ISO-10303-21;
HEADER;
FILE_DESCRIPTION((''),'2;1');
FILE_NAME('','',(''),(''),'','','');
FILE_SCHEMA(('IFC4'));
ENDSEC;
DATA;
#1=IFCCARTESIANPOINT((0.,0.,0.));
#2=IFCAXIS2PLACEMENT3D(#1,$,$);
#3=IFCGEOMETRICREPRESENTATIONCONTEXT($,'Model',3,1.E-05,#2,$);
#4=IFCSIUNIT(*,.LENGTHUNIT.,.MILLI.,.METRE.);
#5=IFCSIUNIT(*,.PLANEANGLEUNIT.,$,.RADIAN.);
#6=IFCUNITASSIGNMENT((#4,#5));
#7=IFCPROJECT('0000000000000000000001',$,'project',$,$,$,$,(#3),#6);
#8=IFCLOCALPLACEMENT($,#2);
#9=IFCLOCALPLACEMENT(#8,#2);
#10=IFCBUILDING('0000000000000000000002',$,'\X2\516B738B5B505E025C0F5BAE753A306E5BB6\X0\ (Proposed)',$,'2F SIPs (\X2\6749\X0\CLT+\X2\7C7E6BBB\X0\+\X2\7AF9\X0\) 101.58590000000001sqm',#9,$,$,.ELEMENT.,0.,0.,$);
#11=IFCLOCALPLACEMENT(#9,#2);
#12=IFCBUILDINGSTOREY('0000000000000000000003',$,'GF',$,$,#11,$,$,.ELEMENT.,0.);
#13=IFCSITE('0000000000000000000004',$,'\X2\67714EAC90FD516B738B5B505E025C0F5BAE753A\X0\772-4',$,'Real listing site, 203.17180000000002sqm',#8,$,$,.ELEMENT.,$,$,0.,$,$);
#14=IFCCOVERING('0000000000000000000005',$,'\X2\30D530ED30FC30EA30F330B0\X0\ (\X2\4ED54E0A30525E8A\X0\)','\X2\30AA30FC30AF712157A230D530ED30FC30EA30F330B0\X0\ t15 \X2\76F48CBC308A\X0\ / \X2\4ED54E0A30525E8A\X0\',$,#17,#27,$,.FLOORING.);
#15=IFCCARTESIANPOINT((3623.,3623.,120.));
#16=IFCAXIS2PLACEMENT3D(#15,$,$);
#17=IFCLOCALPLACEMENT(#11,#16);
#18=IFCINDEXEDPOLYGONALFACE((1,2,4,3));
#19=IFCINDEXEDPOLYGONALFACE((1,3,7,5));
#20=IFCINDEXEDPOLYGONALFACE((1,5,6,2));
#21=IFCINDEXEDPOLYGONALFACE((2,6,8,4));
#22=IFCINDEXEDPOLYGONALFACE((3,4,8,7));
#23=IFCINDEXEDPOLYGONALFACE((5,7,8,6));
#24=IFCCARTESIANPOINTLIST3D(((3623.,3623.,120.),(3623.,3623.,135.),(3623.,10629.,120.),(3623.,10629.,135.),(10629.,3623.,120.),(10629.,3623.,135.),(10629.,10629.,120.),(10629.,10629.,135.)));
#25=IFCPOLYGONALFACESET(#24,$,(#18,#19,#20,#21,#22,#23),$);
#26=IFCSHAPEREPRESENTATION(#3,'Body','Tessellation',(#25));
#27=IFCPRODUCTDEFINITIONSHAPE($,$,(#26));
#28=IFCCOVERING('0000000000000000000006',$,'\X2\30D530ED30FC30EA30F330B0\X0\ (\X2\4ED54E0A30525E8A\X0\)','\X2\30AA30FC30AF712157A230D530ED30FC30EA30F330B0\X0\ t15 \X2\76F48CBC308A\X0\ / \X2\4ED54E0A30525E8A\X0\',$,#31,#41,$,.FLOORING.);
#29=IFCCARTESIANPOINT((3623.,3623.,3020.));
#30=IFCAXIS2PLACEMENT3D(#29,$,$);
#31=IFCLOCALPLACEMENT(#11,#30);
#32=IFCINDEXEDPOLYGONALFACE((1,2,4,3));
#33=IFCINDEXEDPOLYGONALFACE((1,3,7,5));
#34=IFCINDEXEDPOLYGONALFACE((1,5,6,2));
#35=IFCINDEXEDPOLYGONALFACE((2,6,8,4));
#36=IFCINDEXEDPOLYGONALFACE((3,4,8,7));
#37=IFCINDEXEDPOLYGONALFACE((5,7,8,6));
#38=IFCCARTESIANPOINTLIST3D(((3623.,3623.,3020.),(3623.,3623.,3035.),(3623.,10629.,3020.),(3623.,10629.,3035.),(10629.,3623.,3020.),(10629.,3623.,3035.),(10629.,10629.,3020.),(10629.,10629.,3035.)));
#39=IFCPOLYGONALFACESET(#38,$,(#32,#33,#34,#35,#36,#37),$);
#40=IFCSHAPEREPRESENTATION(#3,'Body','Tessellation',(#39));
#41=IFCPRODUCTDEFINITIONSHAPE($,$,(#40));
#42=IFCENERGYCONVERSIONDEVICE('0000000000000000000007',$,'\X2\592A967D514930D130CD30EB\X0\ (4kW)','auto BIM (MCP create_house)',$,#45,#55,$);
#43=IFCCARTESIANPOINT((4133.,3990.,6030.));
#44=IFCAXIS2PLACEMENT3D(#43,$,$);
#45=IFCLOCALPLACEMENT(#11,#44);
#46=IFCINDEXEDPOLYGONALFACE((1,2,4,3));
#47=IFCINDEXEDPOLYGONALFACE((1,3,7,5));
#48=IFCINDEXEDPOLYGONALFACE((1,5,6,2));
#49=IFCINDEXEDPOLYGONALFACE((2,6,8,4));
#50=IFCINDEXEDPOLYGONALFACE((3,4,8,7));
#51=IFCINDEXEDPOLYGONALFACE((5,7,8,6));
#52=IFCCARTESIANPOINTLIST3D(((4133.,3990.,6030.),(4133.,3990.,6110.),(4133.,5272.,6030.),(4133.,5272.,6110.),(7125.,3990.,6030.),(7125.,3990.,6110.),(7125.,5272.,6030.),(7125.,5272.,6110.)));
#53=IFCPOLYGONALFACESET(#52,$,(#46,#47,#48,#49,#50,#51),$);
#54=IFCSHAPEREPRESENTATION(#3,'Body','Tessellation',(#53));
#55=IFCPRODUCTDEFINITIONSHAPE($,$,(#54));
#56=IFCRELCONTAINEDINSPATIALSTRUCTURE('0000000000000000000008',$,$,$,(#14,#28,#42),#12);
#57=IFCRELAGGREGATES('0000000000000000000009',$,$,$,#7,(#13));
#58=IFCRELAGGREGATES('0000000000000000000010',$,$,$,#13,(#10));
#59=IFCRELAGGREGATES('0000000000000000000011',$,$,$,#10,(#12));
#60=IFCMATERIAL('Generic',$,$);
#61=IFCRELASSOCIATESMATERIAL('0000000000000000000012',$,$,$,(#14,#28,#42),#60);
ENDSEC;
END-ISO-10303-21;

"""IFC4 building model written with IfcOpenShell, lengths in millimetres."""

from ifc_helpers import new_model, si_unit, frame, frame_2d, origin, place, context, project, spatial, rectangle, extrude, material, element, save


model = new_model("IFC4")

# Units and contexts
model_context = context("Model", 3, precision=1e-05, world=origin())
ifc_project = project(units=[si_unit("LENGTHUNIT", "METRE", prefix="MILLI"), si_unit("PLANEANGLEUNIT", "RADIAN")], contexts=[model_context])

# Site, building, storey
site_placement = place(None, origin())
site = spatial("IfcSite", under=ifc_project, at=site_placement, Name="東京都八王子市小宮町772-4", ObjectType="Real listing site, 203.17180000000002sqm", CompositionType="ELEMENT", RefElevation=0.0)
building_placement = place(site_placement, origin())
building = spatial("IfcBuilding", under=site, at=building_placement, Name="八王子市小宮町の家 (Proposed)", ObjectType="2F SIPs (杉CLT+籾殻+竹) 101.58590000000001sqm", CompositionType="ELEMENT", ElevationOfRefHeight=0.0, ElevationOfTerrain=0.0)
storey_placement = place(building_placement, origin())
storey = spatial("IfcBuildingStorey", under=building, at=storey_placement, Name="GF", CompositionType="ELEMENT", Elevation=0.0)

# Coverings
ifc_material_1 = material(Name="Generic")
covering_1_placement = place(storey_placement, frame((3623.0, 3623.0, 120.0)))
element("IfcCovering", 1, at=covering_1_placement, inside=storey, material=ifc_material_1, Name="フローリング (仕上げ床)", Description="オーク無垢フローリング t15 直貼り / 仕上げ床", PredefinedType="FLOORING", context=model_context, shape_type="SweptSolid", body=[
    extrude(rectangle(XDim=7006.0, YDim=7006.0, at=frame_2d((3503.0, 3503.0))), frame((3623.0, 3623.0, 120.0)), (0.0, 0.0, 1.0), 15.0),
])
covering_2_placement = place(storey_placement, frame((3623.0, 3623.0, 3020.0)))
element("IfcCovering", 2, at=covering_2_placement, inside=storey, material=ifc_material_1, Name="フローリング (仕上げ床)", Description="オーク無垢フローリング t15 直貼り / 仕上げ床", PredefinedType="FLOORING", context=model_context, shape_type="SweptSolid", body=[
    extrude(rectangle(XDim=7006.0, YDim=7006.0, at=frame_2d((3503.0, 3503.0))), frame((3623.0, 3623.0, 3020.0)), (0.0, 0.0, 1.0), 15.0),
])

# Energy conversion device
energy_conversion_device_placement = place(storey_placement, frame((4133.0, 3990.0, 6030.0)))
element("IfcEnergyConversionDevice", 3, at=energy_conversion_device_placement, inside=storey, material=ifc_material_1, Name="太陽光パネル (4kW)", Description="auto BIM (MCP create_house)", context=model_context, shape_type="SweptSolid", body=[
    extrude(rectangle(XDim=2992.0, YDim=1282.0, at=frame_2d((1496.0, 641.0))), frame((4133.0, 3990.0, 6030.0)), (0.0, 0.0, 1.0), 80.0),
])

save(model, "model.ifc")
